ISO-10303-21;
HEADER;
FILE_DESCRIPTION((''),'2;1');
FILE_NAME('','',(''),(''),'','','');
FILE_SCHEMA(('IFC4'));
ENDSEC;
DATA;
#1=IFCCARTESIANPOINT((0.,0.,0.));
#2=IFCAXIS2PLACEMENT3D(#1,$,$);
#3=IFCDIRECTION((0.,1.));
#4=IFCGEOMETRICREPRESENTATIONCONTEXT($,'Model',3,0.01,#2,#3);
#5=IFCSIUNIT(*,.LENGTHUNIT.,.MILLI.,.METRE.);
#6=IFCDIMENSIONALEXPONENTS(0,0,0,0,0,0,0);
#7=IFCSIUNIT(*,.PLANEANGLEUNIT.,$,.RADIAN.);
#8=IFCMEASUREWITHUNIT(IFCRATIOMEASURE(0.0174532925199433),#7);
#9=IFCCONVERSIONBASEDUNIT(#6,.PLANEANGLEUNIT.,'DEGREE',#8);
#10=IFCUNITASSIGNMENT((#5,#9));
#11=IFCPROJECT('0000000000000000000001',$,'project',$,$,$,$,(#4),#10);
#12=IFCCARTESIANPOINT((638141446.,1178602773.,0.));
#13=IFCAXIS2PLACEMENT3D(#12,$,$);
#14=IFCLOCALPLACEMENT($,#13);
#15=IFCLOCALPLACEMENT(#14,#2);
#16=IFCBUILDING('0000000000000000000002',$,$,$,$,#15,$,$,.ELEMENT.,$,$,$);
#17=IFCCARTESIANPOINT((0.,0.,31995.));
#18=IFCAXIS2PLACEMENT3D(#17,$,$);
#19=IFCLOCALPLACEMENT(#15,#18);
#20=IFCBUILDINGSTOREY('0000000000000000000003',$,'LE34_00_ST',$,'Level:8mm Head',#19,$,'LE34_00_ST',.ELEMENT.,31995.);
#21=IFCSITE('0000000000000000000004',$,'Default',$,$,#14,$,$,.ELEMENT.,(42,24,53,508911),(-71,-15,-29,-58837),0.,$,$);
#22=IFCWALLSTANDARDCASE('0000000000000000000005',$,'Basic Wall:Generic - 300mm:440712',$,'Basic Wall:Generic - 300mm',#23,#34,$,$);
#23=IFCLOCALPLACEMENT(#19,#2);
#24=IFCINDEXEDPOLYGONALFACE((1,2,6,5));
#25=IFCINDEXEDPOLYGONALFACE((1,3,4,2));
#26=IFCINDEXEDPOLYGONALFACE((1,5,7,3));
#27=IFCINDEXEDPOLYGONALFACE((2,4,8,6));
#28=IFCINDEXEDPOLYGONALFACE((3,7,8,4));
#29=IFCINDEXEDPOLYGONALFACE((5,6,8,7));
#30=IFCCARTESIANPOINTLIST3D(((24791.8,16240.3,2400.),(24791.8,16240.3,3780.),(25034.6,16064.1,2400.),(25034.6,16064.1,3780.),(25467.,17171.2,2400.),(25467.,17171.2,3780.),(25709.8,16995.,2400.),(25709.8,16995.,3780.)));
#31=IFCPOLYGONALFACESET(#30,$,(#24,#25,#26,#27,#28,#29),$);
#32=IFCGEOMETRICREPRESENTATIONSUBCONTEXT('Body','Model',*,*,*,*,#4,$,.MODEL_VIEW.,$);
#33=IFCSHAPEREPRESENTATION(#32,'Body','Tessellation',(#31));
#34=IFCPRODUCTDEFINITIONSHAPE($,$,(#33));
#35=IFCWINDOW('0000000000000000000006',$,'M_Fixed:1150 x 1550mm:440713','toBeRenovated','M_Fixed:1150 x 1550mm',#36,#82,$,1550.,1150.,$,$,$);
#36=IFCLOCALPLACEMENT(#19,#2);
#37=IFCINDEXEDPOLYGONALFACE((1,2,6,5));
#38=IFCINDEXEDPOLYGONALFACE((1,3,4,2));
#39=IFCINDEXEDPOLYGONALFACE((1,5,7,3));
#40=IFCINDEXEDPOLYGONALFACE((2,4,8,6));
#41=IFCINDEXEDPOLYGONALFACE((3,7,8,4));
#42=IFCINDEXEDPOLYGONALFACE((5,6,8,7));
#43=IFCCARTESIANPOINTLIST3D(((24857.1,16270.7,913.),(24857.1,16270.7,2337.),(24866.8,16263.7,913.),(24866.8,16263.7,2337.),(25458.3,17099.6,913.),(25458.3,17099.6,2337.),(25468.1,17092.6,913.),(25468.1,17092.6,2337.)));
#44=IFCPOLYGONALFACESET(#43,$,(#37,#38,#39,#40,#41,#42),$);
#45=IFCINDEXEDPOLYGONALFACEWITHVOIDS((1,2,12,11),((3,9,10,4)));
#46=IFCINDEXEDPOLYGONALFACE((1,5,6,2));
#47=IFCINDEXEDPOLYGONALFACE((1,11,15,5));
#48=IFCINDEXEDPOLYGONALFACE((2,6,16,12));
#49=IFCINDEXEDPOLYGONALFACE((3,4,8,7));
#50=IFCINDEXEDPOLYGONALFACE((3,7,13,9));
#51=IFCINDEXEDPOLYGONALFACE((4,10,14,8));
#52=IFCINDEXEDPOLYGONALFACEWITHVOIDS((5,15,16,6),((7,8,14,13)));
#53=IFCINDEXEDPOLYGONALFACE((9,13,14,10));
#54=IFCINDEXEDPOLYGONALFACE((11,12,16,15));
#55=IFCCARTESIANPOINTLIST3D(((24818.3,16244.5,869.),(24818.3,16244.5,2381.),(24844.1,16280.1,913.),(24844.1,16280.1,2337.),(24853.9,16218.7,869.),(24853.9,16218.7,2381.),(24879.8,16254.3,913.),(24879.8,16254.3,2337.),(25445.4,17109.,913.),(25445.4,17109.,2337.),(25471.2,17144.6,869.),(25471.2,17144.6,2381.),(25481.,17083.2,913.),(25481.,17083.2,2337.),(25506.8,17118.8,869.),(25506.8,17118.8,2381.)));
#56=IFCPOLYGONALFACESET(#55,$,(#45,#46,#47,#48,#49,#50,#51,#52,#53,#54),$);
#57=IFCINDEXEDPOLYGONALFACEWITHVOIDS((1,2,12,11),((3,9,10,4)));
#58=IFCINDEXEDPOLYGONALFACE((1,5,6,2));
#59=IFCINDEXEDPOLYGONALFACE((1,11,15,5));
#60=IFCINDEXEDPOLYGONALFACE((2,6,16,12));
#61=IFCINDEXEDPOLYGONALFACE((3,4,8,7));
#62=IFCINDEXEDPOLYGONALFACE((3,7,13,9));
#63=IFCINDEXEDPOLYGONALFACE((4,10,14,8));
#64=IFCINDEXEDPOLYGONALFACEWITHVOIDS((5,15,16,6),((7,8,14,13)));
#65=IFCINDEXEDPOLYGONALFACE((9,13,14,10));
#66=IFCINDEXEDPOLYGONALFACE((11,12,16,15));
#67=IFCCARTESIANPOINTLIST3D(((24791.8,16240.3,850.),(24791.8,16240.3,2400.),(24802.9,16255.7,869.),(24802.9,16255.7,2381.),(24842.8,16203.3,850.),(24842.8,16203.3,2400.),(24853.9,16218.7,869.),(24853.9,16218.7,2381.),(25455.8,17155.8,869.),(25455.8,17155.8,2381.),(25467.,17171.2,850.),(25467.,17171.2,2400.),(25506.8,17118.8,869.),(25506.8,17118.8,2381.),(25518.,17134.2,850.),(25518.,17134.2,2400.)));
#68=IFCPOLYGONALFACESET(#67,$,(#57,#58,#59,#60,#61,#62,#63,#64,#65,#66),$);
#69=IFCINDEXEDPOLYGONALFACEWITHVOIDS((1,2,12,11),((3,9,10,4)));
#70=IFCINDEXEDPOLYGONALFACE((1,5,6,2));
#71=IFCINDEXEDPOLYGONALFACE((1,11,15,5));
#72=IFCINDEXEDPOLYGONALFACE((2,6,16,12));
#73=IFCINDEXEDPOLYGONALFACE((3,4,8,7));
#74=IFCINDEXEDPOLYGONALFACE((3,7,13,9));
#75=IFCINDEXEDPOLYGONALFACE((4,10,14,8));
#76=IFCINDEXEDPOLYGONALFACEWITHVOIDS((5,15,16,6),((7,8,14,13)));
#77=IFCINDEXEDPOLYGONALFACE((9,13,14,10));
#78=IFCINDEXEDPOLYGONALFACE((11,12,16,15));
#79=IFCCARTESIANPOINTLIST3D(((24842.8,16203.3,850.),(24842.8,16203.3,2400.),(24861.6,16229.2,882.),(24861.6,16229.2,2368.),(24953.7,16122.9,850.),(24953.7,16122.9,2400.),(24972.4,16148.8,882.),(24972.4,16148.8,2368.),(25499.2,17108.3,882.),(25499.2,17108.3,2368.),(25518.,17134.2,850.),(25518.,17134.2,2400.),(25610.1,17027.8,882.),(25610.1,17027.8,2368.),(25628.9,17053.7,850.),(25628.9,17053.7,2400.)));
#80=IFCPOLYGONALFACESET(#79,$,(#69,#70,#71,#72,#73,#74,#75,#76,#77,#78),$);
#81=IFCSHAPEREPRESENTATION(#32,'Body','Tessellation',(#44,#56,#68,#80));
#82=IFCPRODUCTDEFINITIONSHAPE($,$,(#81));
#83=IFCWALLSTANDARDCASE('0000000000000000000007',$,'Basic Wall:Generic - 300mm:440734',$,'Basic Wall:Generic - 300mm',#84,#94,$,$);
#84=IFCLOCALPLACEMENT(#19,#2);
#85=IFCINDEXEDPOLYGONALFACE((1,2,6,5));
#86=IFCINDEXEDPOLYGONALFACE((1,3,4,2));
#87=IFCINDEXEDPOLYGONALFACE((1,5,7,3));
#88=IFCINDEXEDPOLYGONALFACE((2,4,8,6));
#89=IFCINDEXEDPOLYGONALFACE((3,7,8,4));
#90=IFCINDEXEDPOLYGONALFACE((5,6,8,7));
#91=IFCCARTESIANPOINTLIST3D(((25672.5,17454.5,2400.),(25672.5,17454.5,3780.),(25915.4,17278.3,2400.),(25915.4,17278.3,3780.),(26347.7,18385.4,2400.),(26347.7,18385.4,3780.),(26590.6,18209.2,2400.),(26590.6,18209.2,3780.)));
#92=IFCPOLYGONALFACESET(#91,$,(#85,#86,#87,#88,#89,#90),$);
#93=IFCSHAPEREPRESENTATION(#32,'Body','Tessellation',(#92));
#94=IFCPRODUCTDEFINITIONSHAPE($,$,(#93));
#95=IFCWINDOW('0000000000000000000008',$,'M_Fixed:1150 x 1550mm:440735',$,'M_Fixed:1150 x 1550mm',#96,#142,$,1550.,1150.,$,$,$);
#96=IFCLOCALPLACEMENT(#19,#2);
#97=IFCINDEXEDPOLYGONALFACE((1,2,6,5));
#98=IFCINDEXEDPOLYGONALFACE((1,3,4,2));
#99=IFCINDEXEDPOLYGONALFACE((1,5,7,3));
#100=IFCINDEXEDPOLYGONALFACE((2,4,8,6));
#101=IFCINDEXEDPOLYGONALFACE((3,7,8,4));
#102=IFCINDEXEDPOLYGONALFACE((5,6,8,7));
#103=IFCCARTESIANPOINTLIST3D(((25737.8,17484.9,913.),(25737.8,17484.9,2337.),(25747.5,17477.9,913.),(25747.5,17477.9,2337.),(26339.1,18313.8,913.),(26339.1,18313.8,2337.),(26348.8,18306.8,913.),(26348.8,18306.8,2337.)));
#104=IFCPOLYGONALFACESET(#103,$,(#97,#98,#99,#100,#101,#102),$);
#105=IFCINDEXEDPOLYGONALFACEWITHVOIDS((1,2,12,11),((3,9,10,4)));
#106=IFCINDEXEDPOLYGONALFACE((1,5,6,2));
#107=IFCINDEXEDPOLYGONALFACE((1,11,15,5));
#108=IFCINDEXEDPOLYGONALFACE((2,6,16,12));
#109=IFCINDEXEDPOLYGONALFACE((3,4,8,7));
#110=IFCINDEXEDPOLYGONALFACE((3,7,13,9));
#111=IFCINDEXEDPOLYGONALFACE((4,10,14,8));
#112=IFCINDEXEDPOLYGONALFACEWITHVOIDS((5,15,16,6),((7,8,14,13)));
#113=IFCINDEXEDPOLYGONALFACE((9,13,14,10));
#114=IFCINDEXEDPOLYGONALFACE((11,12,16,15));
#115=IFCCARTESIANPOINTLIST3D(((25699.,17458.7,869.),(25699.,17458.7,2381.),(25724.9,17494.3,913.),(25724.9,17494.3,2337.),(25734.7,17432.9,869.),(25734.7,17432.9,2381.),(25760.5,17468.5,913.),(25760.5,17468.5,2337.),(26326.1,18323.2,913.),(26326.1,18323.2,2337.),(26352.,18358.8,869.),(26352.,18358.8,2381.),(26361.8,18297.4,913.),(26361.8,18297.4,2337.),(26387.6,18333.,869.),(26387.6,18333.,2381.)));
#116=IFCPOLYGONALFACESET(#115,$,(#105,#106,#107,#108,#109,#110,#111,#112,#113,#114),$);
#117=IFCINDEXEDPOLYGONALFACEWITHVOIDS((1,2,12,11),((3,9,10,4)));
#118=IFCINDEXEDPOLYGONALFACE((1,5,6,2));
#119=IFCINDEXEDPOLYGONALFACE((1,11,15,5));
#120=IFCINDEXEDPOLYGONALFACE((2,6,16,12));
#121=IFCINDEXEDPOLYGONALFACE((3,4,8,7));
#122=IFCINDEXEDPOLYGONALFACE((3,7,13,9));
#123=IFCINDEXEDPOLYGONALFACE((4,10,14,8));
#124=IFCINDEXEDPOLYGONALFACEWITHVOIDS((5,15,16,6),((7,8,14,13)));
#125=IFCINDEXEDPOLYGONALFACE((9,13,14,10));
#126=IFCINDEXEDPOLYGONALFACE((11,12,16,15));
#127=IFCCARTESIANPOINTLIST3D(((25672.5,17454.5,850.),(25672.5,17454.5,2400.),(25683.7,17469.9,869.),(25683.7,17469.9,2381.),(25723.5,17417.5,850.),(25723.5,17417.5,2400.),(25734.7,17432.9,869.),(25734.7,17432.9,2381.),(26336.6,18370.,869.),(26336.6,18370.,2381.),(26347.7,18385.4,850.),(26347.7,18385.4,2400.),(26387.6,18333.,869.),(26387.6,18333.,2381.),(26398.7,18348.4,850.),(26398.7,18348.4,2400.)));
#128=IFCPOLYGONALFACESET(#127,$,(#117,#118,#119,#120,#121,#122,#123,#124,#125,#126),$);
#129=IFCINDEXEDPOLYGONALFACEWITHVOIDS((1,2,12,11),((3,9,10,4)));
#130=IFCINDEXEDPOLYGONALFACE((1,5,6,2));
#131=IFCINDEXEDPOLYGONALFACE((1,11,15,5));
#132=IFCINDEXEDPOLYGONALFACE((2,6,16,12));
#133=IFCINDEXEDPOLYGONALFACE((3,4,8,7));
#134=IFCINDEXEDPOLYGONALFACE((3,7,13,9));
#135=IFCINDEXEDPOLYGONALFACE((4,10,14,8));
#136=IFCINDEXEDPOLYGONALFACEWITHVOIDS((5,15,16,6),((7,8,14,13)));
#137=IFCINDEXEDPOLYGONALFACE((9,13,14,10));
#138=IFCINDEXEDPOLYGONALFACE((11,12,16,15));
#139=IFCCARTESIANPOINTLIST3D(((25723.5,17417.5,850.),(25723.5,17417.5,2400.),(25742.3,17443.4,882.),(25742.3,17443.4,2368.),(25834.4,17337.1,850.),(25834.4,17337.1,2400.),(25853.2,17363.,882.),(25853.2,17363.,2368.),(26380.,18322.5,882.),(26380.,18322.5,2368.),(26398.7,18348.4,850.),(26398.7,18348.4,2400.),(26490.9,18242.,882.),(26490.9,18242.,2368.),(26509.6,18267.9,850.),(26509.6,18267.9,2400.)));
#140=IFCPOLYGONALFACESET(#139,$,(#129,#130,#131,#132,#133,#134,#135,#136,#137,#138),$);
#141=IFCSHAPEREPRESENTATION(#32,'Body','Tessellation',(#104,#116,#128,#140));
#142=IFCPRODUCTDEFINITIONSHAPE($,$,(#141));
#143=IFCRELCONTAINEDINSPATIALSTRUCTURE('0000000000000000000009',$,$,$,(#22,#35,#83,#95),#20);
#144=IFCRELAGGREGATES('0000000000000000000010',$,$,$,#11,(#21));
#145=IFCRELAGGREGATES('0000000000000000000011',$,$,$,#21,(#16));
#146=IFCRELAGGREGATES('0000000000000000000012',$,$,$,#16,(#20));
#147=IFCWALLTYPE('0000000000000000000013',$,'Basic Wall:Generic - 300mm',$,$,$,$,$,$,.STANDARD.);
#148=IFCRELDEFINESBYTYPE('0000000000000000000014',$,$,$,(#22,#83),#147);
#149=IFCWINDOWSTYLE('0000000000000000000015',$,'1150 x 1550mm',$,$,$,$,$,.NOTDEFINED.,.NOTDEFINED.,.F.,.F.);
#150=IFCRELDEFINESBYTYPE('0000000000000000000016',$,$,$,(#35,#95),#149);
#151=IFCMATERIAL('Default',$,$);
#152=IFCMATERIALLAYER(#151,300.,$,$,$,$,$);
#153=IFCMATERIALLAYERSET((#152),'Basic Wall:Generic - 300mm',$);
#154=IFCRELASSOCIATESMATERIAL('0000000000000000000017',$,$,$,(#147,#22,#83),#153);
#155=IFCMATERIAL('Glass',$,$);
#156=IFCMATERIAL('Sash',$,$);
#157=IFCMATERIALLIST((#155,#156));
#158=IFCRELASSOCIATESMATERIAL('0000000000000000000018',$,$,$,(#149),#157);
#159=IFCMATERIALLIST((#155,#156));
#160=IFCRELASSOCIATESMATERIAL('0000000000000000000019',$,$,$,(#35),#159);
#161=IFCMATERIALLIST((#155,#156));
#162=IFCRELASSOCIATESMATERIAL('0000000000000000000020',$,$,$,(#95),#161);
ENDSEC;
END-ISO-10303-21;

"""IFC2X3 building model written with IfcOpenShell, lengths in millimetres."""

from ifc_helpers import new_model, entity, si_unit, converted_unit, direction, frame, frame_2d, origin, place, context, subcontext, project, spatial, polyline, rectangle, outline, extrude, source, transform, mapped, material, material_list, layer, layer_set, layer_usage, type_object, type_shapes, element, fill, save


model = new_model("IFC2X3")

# Units and contexts
model_context = context("Model", 3, precision=0.01, world=origin(), true_north=direction((0.0, 1.0)))
body_context = subcontext(model_context, "Body", "Model", "MODEL_VIEW")
ifc_project = project(units=[si_unit("LENGTHUNIT", "METRE", prefix="MILLI"), converted_unit("PLANEANGLEUNIT", "DEGREE", entity("IfcRatioMeasure", 0.0174532925199433), si_unit("PLANEANGLEUNIT", "RADIAN"), dimensions=[0, 0, 0, 0, 0, 0, 0])], contexts=[model_context])

# Site, building, storey
site_placement = place(None, frame((638141446.0, 1178602773.0, 0.0)))
site = spatial("IfcSite", under=ifc_project, at=site_placement, Name="Default", CompositionType="ELEMENT", RefLatitude=(42, 24, 53, 508911), RefLongitude=(-71, -15, -29, -58837), RefElevation=0.0)
building_placement = place(site_placement, origin())
building = spatial("IfcBuilding", under=site, at=building_placement, CompositionType="ELEMENT")
storey_placement = place(building_placement, frame((0.0, 0.0, 31995.0)))
storey = spatial("IfcBuildingStorey", under=building, at=storey_placement, Name="LE34_00_ST", ObjectType="Level:8mm Head", LongName="LE34_00_ST", CompositionType="ELEMENT", Elevation=31995.0)

# Walls, openings, windows
ifc_material_1 = material(Name="Default")
ifc_layer_1 = layer(ifc_material_1, 300.0)
ifc_layer_set_1 = layer_set([ifc_layer_1], Name="Basic Wall:Generic - 300mm")
wall_type_1 = type_object("IfcWallType", Name="Basic Wall:Generic - 300mm", PredefinedType="STANDARD", material=ifc_layer_set_1)
ifc_material_2 = material(Name="Glass")
ifc_material_3 = material(Name="Sash")
ifc_material_list_1 = material_list([ifc_material_2, ifc_material_3])
window_style_1 = type_object("IfcWindowStyle", Name="1150 x 1550mm", ConstructionType="NOTDEFINED", OperationType="NOTDEFINED", ParameterTakesPrecedence=False, Sizeable=False, material=ifc_material_list_1)
shared_shape_1 = source(origin(), body_context, "Body", "SweptSolid", [
    extrude(rectangle(XDim=12.0, YDim=1024.0, at=frame_2d((0.0, 0.0), x_axis=(1.0, 0.0))), frame((575.0, 259.0, 63.0), z_axis=(0.0, 0.0, 1.0), x_axis=(0.0, -1.0, 0.0)), (0.0, 0.0, 1.0), 1424.0),
    extrude(outline(polyline([(-556.0, -756.0), (556.0, -756.0), (556.0, 756.0), (-556.0, 756.0), (-556.0, -756.0)]), holes=[polyline([(-512.0, -712.0), (-512.0, 712.0), (512.0, 712.0), (512.0, -712.0), (-512.0, -712.0)])]), frame((575.0, 237.0, 775.0), z_axis=(0.0, 1.0, 0.0), x_axis=(1.0, 0.0, 0.0)), (0.0, 0.0, 1.0), 44.0),
    extrude(outline(polyline([(-575.0, -775.0), (575.0, -775.0), (575.0, 775.0), (-575.0, 775.0), (-575.0, -775.0)]), holes=[polyline([(-556.0, -756.0), (-556.0, 756.0), (556.0, 756.0), (556.0, -756.0), (-556.0, -756.0)])]), frame((575.0, 237.0, 775.0), z_axis=(0.0, 1.0, 0.0), x_axis=(1.0, 0.0, 0.0)), (0.0, 0.0, 1.0), 63.0),
    extrude(outline(polyline([(-575.0, -775.0), (575.0, -775.0), (575.0, 775.0), (-575.0, 775.0), (-575.0, -775.0)]), holes=[polyline([(-543.0, -743.0), (-543.0, 743.0), (543.0, 743.0), (543.0, -743.0), (-543.0, -743.0)])]), frame((575.0, 100.0, 775.0), z_axis=(0.0, 1.0, 0.0), x_axis=(1.0, 0.0, 0.0)), (0.0, 0.0, 1.0), 137.0),
])
type_shapes(window_style_1, [shared_shape_1])
ifc_layer_usage_1 = layer_usage(ifc_layer_set_1, "AXIS2", "NEGATIVE", 150.0)
wall_1_placement = place(storey_placement, frame((24913.2, 16152.2, 2400.0), z_axis=(0.0, 0.0, 1.0), x_axis=(0.587164, 0.809468, 0.0)))
wall_1 = element("IfcWallStandardCase", 1, at=wall_1_placement, inside=storey, type_object=wall_type_1, material=ifc_layer_usage_1, Name="Basic Wall:Generic - 300mm:440712", ObjectType="Basic Wall:Generic - 300mm", context=body_context, shape_type="SweptSolid", body=[
    extrude(rectangle(XDim=1150.0, YDim=300.0, at=frame_2d((575.0, 0.0), x_axis=(-1.0, 0.0))), origin(), (0.0, 0.0, 1.0), 1380.0),
])
opening_1_placement = place(wall_1_placement, frame((0.0, -150.0, -1550.0)))
opening_1 = element("IfcOpeningElement", 2, at=opening_1_placement, cuts=wall_1, ObjectType="Opening", context=body_context, shape_type="SweptSolid", body=[
    extrude(rectangle(XDim=1550.0, YDim=1150.0, at=frame_2d((775.0, 575.0), x_axis=(1.0, 0.0))), frame((0.0, 0.0, 0.0), z_axis=(0.0, 1.0, 0.0), x_axis=(0.0, 0.0, 1.0)), (0.0, 0.0, 1.0), 300.0),
])
ifc_material_list_2 = material_list([ifc_material_2, ifc_material_3])
window_1_placement = place(opening_1_placement, origin())
window_1 = element("IfcWindow", 3, at=window_1_placement, inside=storey, type_object=window_style_1, material=ifc_material_list_2, Name="M_Fixed:1150 x 1550mm:440713", Description="toBeRenovated", ObjectType="M_Fixed:1150 x 1550mm", OverallHeight=1550.0, OverallWidth=1150.0, context=body_context, shape_type="MappedRepresentation", body=[
    mapped(shared_shape_1, transform((0.0, 0.0, 0.0), scale=1.0)),
])
fill(opening_1, window_1)
ifc_layer_usage_2 = layer_usage(ifc_layer_set_1, "AXIS2", "NEGATIVE", 150.0)
wall_2_placement = place(storey_placement, frame((25793.9, 17366.4, 2400.0), z_axis=(0.0, 0.0, 1.0), x_axis=(0.587164, 0.809468, 0.0)))
wall_2 = element("IfcWallStandardCase", 4, at=wall_2_placement, inside=storey, type_object=wall_type_1, material=ifc_layer_usage_2, Name="Basic Wall:Generic - 300mm:440734", ObjectType="Basic Wall:Generic - 300mm", context=body_context, shape_type="SweptSolid", body=[
    extrude(rectangle(XDim=1150.0, YDim=300.0, at=frame_2d((575.0, 0.0), x_axis=(-1.0, 0.0))), origin(), (0.0, 0.0, 1.0), 1380.0),
])
opening_2_placement = place(wall_2_placement, frame((0.0, -150.0, -1550.0)))
opening_2 = element("IfcOpeningElement", 5, at=opening_2_placement, cuts=wall_2, ObjectType="Opening", context=body_context, shape_type="SweptSolid", body=[
    extrude(rectangle(XDim=1550.0, YDim=1150.0, at=frame_2d((775.0, 575.0), x_axis=(1.0, 0.0))), frame((0.0, 0.0, 0.0), z_axis=(0.0, 1.0, 0.0), x_axis=(0.0, 0.0, 1.0)), (0.0, 0.0, 1.0), 300.0),
])
ifc_material_list_3 = material_list([ifc_material_2, ifc_material_3])
window_2_placement = place(opening_2_placement, origin())
window_2 = element("IfcWindow", 6, at=window_2_placement, inside=storey, type_object=window_style_1, material=ifc_material_list_3, Name="M_Fixed:1150 x 1550mm:440735", ObjectType="M_Fixed:1150 x 1550mm", OverallHeight=1550.0, OverallWidth=1150.0, context=body_context, shape_type="MappedRepresentation", body=[
    mapped(shared_shape_1, transform((0.0, 0.0, 0.0), scale=1.0)),
])
fill(opening_2, window_2)

save(model, "model.ifc")
